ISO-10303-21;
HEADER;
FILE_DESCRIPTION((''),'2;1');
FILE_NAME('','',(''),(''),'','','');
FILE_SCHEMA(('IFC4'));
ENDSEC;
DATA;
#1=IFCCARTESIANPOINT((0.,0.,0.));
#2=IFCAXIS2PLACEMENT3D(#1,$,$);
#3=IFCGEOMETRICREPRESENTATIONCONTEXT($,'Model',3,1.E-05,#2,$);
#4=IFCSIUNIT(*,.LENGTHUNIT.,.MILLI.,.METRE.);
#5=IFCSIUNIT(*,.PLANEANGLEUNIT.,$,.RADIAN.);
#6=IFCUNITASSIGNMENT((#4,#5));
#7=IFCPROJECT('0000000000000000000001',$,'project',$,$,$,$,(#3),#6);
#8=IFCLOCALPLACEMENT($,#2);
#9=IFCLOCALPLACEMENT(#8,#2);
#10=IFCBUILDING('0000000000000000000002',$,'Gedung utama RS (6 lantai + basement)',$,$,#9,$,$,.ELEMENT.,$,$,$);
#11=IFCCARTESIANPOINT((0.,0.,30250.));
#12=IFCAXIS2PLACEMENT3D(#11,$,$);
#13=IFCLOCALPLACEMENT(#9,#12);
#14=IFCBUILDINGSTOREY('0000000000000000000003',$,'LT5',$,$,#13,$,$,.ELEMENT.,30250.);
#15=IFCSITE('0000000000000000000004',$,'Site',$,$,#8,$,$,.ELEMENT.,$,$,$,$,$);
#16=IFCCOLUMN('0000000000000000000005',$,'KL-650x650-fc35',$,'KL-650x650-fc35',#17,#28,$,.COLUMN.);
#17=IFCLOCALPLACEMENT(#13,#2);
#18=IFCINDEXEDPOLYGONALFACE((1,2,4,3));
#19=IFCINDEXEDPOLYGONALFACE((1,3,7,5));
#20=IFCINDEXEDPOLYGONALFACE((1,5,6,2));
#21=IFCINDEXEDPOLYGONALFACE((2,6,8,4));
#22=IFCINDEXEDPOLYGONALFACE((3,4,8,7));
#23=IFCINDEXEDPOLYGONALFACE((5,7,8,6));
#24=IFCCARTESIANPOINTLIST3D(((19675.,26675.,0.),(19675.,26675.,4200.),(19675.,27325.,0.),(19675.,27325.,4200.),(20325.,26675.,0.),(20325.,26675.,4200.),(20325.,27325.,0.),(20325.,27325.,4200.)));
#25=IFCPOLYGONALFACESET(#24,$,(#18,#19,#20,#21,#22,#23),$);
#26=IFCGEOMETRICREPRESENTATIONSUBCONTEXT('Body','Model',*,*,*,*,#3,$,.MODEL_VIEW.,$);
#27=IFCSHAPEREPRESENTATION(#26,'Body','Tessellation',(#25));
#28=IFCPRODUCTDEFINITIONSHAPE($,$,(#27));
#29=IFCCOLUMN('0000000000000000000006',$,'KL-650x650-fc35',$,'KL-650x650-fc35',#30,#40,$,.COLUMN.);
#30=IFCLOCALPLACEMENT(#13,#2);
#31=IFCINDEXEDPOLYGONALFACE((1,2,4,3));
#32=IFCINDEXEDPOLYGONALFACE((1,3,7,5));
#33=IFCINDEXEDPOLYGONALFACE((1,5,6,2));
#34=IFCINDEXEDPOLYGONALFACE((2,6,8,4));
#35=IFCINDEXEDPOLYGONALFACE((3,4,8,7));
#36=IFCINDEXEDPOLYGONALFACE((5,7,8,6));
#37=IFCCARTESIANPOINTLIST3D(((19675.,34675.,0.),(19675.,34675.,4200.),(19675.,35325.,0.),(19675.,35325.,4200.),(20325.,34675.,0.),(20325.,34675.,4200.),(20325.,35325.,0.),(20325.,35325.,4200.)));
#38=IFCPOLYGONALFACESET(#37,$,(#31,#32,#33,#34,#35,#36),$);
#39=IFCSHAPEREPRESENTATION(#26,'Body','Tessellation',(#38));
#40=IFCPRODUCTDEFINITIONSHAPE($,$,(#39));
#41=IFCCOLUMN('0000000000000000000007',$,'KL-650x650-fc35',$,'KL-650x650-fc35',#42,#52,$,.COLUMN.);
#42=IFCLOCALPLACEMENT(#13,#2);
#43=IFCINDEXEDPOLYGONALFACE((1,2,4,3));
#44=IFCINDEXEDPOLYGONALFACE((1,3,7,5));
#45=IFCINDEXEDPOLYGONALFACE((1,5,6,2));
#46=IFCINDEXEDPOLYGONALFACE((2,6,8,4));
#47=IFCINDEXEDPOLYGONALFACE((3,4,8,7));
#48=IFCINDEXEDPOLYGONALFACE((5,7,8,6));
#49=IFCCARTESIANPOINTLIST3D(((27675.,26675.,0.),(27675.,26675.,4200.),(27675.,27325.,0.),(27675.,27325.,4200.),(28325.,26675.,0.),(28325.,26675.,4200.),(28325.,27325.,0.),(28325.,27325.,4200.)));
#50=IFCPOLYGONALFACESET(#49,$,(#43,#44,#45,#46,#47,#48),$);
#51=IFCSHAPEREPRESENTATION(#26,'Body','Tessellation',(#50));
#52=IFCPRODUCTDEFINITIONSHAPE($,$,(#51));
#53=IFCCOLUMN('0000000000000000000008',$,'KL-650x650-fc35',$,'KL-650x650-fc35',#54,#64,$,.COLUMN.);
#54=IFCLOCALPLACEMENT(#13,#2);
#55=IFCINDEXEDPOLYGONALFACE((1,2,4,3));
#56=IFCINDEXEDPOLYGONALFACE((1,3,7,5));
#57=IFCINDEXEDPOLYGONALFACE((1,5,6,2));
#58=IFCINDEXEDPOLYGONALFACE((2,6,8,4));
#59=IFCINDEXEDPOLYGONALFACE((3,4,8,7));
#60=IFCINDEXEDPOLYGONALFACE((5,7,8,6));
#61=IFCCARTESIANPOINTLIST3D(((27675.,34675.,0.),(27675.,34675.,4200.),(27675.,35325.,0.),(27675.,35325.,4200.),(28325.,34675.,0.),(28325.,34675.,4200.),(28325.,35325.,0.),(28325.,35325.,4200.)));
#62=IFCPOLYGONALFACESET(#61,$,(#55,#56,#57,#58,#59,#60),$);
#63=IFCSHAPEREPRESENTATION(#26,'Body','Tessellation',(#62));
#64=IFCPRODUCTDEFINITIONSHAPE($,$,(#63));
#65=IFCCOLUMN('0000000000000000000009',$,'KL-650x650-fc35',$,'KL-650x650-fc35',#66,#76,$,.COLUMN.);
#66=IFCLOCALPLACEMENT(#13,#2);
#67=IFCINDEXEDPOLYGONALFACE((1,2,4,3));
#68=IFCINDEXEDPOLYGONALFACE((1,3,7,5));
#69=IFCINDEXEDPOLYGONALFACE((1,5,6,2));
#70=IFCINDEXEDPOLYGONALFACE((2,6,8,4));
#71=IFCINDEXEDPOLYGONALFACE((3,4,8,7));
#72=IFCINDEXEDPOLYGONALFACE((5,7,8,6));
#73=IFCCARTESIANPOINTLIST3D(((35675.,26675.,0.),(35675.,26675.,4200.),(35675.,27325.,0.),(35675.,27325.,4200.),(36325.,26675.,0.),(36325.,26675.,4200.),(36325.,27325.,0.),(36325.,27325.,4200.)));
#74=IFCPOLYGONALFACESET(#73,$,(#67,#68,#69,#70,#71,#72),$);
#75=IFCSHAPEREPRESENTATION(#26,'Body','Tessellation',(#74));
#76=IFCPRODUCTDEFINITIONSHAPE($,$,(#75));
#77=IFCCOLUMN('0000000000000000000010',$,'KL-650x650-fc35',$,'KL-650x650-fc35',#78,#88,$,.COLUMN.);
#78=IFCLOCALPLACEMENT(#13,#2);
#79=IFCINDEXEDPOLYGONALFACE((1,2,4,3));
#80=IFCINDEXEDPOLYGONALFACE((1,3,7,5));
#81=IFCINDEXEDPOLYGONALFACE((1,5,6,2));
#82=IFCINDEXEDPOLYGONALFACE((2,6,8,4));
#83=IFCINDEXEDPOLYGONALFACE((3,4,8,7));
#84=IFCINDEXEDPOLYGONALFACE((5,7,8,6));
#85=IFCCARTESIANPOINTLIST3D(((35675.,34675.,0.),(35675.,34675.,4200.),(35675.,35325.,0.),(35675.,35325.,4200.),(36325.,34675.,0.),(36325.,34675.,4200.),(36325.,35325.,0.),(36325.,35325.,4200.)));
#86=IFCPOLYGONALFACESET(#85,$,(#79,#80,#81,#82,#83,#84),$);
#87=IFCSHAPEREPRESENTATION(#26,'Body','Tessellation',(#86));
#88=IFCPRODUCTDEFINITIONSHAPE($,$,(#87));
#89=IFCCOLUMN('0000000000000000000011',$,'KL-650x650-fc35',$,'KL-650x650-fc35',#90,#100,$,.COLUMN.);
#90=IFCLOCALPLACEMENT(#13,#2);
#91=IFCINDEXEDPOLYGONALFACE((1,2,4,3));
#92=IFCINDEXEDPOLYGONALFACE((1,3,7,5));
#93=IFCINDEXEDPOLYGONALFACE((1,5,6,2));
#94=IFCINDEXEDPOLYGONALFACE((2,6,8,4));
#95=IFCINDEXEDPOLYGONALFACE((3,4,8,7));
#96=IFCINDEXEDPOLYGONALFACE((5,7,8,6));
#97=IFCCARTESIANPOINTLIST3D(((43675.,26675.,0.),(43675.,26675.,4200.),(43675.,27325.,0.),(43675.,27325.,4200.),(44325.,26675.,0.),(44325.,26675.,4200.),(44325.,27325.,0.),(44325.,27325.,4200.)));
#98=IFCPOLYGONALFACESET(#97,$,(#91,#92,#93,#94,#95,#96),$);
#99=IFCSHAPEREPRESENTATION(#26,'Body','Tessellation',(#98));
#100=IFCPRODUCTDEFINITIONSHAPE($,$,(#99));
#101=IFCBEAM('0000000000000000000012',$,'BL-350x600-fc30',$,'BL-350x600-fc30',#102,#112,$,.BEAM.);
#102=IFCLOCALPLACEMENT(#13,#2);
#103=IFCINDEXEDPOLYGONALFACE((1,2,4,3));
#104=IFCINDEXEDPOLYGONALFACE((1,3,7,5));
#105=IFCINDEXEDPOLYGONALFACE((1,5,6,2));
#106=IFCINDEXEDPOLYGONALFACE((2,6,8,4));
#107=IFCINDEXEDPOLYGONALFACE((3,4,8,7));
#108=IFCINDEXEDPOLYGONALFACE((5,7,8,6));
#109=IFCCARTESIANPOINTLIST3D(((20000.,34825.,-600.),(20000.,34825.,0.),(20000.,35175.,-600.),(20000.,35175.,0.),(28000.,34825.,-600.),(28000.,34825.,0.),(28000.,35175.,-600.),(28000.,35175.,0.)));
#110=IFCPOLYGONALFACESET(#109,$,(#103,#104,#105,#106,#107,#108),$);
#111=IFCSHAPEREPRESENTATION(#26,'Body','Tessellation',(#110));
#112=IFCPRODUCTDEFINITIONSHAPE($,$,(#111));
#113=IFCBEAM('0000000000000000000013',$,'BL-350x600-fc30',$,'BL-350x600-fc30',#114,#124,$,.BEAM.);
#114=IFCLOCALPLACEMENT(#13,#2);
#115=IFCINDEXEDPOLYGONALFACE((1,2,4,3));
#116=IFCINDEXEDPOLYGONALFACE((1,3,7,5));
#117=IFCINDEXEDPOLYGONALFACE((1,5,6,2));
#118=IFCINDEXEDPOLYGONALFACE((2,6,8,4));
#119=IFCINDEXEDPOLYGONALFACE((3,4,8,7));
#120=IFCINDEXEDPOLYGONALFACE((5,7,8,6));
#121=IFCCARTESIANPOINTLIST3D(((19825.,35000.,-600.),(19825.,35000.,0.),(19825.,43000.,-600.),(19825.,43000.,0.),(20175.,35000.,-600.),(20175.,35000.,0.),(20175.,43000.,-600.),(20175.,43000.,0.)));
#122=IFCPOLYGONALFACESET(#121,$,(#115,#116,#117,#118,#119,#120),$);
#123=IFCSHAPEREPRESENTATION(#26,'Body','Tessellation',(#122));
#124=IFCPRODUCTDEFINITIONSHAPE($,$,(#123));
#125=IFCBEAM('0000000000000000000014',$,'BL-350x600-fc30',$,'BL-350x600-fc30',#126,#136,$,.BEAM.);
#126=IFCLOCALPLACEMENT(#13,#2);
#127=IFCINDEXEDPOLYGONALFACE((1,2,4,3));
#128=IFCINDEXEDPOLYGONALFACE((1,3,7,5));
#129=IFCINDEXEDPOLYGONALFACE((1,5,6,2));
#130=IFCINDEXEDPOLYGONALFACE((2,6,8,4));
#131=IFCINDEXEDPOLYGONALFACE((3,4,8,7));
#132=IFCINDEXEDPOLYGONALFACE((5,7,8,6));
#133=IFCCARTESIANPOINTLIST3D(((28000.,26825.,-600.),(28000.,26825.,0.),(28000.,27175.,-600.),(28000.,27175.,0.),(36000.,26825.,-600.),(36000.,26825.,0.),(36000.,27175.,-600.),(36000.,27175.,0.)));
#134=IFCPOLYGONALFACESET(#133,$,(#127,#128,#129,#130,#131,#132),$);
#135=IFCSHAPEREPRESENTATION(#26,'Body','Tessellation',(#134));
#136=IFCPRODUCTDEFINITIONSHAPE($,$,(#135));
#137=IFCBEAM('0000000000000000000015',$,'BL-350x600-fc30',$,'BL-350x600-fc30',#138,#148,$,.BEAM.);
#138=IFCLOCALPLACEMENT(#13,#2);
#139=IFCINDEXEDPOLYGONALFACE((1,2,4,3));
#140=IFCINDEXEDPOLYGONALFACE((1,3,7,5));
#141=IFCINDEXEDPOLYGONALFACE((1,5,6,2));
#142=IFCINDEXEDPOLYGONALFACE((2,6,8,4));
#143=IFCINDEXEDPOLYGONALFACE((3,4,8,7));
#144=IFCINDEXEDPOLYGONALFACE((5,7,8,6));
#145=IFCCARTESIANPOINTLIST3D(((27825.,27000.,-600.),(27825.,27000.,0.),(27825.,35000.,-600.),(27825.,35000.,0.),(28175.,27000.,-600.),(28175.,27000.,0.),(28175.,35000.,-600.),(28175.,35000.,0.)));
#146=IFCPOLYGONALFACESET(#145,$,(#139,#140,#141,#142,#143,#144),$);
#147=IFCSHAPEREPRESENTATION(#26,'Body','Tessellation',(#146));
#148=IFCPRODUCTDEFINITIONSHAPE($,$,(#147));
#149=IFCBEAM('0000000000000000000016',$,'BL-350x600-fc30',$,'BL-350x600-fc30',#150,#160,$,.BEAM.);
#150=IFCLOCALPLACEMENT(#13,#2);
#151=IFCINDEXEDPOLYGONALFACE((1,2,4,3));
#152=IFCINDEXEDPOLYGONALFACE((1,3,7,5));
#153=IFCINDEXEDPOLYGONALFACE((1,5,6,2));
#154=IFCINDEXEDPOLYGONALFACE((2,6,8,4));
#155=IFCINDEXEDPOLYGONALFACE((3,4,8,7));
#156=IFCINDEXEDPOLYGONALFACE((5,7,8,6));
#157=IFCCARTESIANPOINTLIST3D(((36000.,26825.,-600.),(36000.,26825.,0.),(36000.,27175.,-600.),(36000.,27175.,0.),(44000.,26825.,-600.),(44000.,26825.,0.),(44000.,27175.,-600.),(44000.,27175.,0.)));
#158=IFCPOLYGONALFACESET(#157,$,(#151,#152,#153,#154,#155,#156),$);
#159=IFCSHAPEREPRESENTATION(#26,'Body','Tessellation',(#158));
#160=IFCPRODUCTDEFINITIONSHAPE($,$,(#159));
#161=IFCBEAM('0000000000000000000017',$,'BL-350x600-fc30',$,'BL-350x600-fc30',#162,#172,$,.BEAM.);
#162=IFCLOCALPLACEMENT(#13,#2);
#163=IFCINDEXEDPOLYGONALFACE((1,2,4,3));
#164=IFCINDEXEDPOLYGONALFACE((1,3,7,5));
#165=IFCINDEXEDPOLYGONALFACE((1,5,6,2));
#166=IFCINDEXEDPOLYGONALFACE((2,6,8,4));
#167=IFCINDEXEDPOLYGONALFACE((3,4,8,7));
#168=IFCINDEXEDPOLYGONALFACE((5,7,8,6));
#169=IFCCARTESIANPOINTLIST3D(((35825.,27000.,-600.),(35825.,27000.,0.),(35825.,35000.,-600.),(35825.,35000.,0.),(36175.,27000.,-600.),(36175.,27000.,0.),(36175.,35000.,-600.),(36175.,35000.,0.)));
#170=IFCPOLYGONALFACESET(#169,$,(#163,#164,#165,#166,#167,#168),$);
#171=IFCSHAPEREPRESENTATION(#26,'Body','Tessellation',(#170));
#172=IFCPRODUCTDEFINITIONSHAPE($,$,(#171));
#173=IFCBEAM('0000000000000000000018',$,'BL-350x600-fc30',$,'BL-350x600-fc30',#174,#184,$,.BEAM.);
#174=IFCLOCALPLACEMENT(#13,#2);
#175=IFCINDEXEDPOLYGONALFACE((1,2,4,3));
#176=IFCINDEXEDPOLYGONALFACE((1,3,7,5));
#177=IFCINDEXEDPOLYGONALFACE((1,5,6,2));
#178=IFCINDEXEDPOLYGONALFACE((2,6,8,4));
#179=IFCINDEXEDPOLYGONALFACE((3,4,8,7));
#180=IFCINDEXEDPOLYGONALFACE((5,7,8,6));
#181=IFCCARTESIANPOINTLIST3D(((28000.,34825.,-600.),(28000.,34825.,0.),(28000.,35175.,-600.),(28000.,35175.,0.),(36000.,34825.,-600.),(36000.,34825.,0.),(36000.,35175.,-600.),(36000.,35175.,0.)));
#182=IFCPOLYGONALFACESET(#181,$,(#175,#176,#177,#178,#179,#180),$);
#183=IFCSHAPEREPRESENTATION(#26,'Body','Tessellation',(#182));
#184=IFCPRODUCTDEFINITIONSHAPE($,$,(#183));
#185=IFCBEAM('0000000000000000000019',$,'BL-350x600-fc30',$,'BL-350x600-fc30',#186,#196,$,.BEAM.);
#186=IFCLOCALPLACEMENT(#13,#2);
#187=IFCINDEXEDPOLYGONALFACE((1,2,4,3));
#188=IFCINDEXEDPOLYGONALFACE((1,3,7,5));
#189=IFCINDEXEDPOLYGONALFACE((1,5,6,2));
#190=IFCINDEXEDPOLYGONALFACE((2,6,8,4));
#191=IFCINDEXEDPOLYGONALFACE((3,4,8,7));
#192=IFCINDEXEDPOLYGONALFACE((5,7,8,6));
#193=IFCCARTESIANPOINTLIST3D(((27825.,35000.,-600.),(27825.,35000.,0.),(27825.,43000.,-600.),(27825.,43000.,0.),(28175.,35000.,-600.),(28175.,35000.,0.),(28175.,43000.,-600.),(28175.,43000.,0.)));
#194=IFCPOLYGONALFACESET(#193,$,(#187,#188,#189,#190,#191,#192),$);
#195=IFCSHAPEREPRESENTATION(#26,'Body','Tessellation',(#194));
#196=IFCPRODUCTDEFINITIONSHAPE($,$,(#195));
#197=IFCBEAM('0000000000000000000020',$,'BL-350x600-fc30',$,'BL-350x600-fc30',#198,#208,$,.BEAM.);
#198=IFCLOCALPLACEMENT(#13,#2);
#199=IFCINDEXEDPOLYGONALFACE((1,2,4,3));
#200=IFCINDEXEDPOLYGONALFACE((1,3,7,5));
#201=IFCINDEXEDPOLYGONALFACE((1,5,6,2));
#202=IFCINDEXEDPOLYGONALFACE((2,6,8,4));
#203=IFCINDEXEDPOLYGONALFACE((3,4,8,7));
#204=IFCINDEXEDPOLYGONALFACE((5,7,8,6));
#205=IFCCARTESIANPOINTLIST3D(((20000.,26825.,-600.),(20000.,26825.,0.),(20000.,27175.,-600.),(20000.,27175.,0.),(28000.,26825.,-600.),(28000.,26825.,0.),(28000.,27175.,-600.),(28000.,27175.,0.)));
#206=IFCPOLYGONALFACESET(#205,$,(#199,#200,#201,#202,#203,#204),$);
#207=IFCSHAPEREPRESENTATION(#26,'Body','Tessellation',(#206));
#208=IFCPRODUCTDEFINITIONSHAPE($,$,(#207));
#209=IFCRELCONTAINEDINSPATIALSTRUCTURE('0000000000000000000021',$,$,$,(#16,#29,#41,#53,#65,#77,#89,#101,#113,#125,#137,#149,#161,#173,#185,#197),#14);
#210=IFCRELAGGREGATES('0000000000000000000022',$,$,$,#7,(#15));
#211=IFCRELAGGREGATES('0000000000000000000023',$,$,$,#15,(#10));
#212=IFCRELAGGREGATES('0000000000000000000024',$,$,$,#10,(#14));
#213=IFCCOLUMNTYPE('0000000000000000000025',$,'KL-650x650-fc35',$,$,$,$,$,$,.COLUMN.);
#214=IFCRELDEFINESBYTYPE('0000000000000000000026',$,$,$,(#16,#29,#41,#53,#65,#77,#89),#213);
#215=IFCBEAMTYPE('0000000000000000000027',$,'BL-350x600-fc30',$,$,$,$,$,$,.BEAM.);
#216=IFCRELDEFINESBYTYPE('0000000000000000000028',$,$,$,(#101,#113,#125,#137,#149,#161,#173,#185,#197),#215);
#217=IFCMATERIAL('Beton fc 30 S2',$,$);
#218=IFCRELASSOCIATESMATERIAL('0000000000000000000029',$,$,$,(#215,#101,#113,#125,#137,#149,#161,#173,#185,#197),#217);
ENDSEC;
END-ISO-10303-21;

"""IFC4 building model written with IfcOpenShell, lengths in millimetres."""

from ifc_helpers import new_model, si_unit, frame, origin, origin_2d, place, context, subcontext, project, spatial, rectangle, extrude, material, material_profile, profile_set, profile_usage, type_object, element, save


model = new_model("IFC4")

# Units and contexts
model_context = context("Model", 3, precision=1e-05, world=origin())
body_context = subcontext(model_context, "Body", "Model", "MODEL_VIEW")
ifc_project = project(units=[si_unit("LENGTHUNIT", "METRE", prefix="MILLI"), si_unit("PLANEANGLEUNIT", "RADIAN")], contexts=[model_context])

# Site, building, storey
site_placement = place(None, origin())
site = spatial("IfcSite", under=ifc_project, at=site_placement, Name="Site", CompositionType="ELEMENT")
building_placement = place(site_placement, origin())
building = spatial("IfcBuilding", under=site, at=building_placement, Name="Gedung utama RS (6 lantai + basement)", CompositionType="ELEMENT")
storey_placement = place(building_placement, frame((0.0, 0.0, 30250.0)))
storey = spatial("IfcBuildingStorey", under=building, at=storey_placement, Name="LT5", CompositionType="ELEMENT", Elevation=30250.0)

# Columns
ifc_material_profile_1 = material_profile(None, rectangle(XDim=650.0, YDim=650.0, at=origin_2d()), Name="KL-650x650-fc35")
ifc_profile_set_1 = profile_set([ifc_material_profile_1], Name="KL-650x650-fc35")
ifc_profile_usage_1 = profile_usage(ifc_profile_set_1, cardinal=5)
column_type = type_object("IfcColumnType", Name="KL-650x650-fc35", PredefinedType="COLUMN", material=ifc_profile_set_1)
for number, where, z_axis, x_axis, name in (
    (1, (20000.0, 27000.0, 0.0), (0.0, 0.0, 1.0), (1.0, 0.0, 0.0), "KL-650x650-fc35"),
    (2, (20000.0, 35000.0, 0.0), (0.0, 0.0, 1.0), (1.0, 0.0, 0.0), "KL-650x650-fc35"),
    (3, (28000.0, 27000.0, 0.0), (0.0, 0.0, 1.0), (1.0, 0.0, 0.0), "KL-650x650-fc35"),
    (4, (28000.0, 35000.0, 0.0), (0.0, 0.0, 1.0), (1.0, 0.0, 0.0), "KL-650x650-fc35"),
    (5, (36000.0, 27000.0, 0.0), (0.0, 0.0, 1.0), (1.0, 0.0, 0.0), "KL-650x650-fc35"),
    (6, (36000.0, 35000.0, 0.0), (0.0, 0.0, 1.0), (1.0, 0.0, 0.0), "KL-650x650-fc35"),
    (7, (44000.0, 27000.0, 0.0), (0.0, 0.0, 1.0), (1.0, 0.0, 0.0), "KL-650x650-fc35"),
):
    element("IfcColumn", number, at=place(storey_placement, frame(where, z_axis=z_axis, x_axis=x_axis)), inside=storey, type_object=column_type, material=ifc_profile_usage_1, Name=name, ObjectType="KL-650x650-fc35", PredefinedType="COLUMN", context=body_context, shape_type="SweptSolid", body=[
        extrude(rectangle(XDim=650.0, YDim=650.0, at=origin_2d()), origin(), (0.0, 0.0, 1.0), 4200.0),
    ])

# Beams
ifc_material_1 = material(Name="Beton fc 30 S2")
ifc_material_profile_2 = material_profile(ifc_material_1, rectangle(XDim=350.0, YDim=600.0, at=origin_2d()), Name="BL-350x600-fc30")
ifc_profile_set_2 = profile_set([ifc_material_profile_2], Name="BL-350x600-fc30")
ifc_profile_usage_2 = profile_usage(ifc_profile_set_2, cardinal=8)
beam_type = type_object("IfcBeamType", Name="BL-350x600-fc30", PredefinedType="BEAM", material=ifc_profile_set_2)
beam_1_placement = place(storey_placement, frame((20000.0, 35000.0, -300.0)))
element("IfcBeam", 8, at=beam_1_placement, inside=storey, type_object=beam_type, material=ifc_profile_usage_2, Name="BL-350x600-fc30", ObjectType="BL-350x600-fc30", PredefinedType="BEAM", context=body_context, shape_type="SweptSolid", body=[
    extrude(rectangle(XDim=350.0, YDim=600.0, at=origin_2d()), frame((0.0, 0.0, 0.0), z_axis=(1.0, 0.0, 0.0), x_axis=(0.0, 1.0, 0.0)), (0.0, 0.0, 1.0), 8000.0),
])
beam_2_placement = place(storey_placement, frame((20000.0, 35000.0, -300.0)))
element("IfcBeam", 9, at=beam_2_placement, inside=storey, type_object=beam_type, material=ifc_profile_usage_2, Name="BL-350x600-fc30", ObjectType="BL-350x600-fc30", PredefinedType="BEAM", context=body_context, shape_type="SweptSolid", body=[
    extrude(rectangle(XDim=350.0, YDim=600.0, at=origin_2d()), frame((0.0, 0.0, 0.0), z_axis=(0.0, 1.0, 0.0), x_axis=(-1.0, 0.0, 0.0)), (0.0, 0.0, 1.0), 8000.0),
])
beam_3_placement = place(storey_placement, frame((28000.0, 27000.0, -300.0)))
element("IfcBeam", 10, at=beam_3_placement, inside=storey, type_object=beam_type, material=ifc_profile_usage_2, Name="BL-350x600-fc30", ObjectType="BL-350x600-fc30", PredefinedType="BEAM", context=body_context, shape_type="SweptSolid", body=[
    extrude(rectangle(XDim=350.0, YDim=600.0, at=origin_2d()), frame((0.0, 0.0, 0.0), z_axis=(1.0, 0.0, 0.0), x_axis=(0.0, 1.0, 0.0)), (0.0, 0.0, 1.0), 8000.0),
])
beam_4_placement = place(storey_placement, frame((28000.0, 27000.0, -300.0)))
element("IfcBeam", 11, at=beam_4_placement, inside=storey, type_object=beam_type, material=ifc_profile_usage_2, Name="BL-350x600-fc30", ObjectType="BL-350x600-fc30", PredefinedType="BEAM", context=body_context, shape_type="SweptSolid", body=[
    extrude(rectangle(XDim=350.0, YDim=600.0, at=origin_2d()), frame((0.0, 0.0, 0.0), z_axis=(0.0, 1.0, 0.0), x_axis=(-1.0, 0.0, 0.0)), (0.0, 0.0, 1.0), 8000.0),
])
beam_5_placement = place(storey_placement, frame((36000.0, 27000.0, -300.0)))
element("IfcBeam", 12, at=beam_5_placement, inside=storey, type_object=beam_type, material=ifc_profile_usage_2, Name="BL-350x600-fc30", ObjectType="BL-350x600-fc30", PredefinedType="BEAM", context=body_context, shape_type="SweptSolid", body=[
    extrude(rectangle(XDim=350.0, YDim=600.0, at=origin_2d()), frame((0.0, 0.0, 0.0), z_axis=(1.0, 0.0, 0.0), x_axis=(0.0, 1.0, 0.0)), (0.0, 0.0, 1.0), 8000.0),
])
beam_6_placement = place(storey_placement, frame((36000.0, 27000.0, -300.0)))
element("IfcBeam", 13, at=beam_6_placement, inside=storey, type_object=beam_type, material=ifc_profile_usage_2, Name="BL-350x600-fc30", ObjectType="BL-350x600-fc30", PredefinedType="BEAM", context=body_context, shape_type="SweptSolid", body=[
    extrude(rectangle(XDim=350.0, YDim=600.0, at=origin_2d()), frame((0.0, 0.0, 0.0), z_axis=(0.0, 1.0, 0.0), x_axis=(-1.0, 0.0, 0.0)), (0.0, 0.0, 1.0), 8000.0),
])
beam_7_placement = place(storey_placement, frame((28000.0, 35000.0, -300.0)))
element("IfcBeam", 14, at=beam_7_placement, inside=storey, type_object=beam_type, material=ifc_profile_usage_2, Name="BL-350x600-fc30", ObjectType="BL-350x600-fc30", PredefinedType="BEAM", context=body_context, shape_type="SweptSolid", body=[
    extrude(rectangle(XDim=350.0, YDim=600.0, at=origin_2d()), frame((0.0, 0.0, 0.0), z_axis=(1.0, 0.0, 0.0), x_axis=(0.0, 1.0, 0.0)), (0.0, 0.0, 1.0), 8000.0),
])
beam_8_placement = place(storey_placement, frame((28000.0, 35000.0, -300.0)))
element("IfcBeam", 15, at=beam_8_placement, inside=storey, type_object=beam_type, material=ifc_profile_usage_2, Name="BL-350x600-fc30", ObjectType="BL-350x600-fc30", PredefinedType="BEAM", context=body_context, shape_type="SweptSolid", body=[
    extrude(rectangle(XDim=350.0, YDim=600.0, at=origin_2d()), frame((0.0, 0.0, 0.0), z_axis=(0.0, 1.0, 0.0), x_axis=(-1.0, 0.0, 0.0)), (0.0, 0.0, 1.0), 8000.0),
])
beam_9_placement = place(storey_placement, frame((20000.0, 27000.0, -300.0)))
element("IfcBeam", 16, at=beam_9_placement, inside=storey, type_object=beam_type, material=ifc_profile_usage_2, Name="BL-350x600-fc30", ObjectType="BL-350x600-fc30", PredefinedType="BEAM", context=body_context, shape_type="SweptSolid", body=[
    extrude(rectangle(XDim=350.0, YDim=600.0, at=origin_2d()), frame((0.0, 0.0, 0.0), z_axis=(1.0, 0.0, 0.0), x_axis=(0.0, 1.0, 0.0)), (0.0, 0.0, 1.0), 8000.0),
])

save(model, "model.ifc")
